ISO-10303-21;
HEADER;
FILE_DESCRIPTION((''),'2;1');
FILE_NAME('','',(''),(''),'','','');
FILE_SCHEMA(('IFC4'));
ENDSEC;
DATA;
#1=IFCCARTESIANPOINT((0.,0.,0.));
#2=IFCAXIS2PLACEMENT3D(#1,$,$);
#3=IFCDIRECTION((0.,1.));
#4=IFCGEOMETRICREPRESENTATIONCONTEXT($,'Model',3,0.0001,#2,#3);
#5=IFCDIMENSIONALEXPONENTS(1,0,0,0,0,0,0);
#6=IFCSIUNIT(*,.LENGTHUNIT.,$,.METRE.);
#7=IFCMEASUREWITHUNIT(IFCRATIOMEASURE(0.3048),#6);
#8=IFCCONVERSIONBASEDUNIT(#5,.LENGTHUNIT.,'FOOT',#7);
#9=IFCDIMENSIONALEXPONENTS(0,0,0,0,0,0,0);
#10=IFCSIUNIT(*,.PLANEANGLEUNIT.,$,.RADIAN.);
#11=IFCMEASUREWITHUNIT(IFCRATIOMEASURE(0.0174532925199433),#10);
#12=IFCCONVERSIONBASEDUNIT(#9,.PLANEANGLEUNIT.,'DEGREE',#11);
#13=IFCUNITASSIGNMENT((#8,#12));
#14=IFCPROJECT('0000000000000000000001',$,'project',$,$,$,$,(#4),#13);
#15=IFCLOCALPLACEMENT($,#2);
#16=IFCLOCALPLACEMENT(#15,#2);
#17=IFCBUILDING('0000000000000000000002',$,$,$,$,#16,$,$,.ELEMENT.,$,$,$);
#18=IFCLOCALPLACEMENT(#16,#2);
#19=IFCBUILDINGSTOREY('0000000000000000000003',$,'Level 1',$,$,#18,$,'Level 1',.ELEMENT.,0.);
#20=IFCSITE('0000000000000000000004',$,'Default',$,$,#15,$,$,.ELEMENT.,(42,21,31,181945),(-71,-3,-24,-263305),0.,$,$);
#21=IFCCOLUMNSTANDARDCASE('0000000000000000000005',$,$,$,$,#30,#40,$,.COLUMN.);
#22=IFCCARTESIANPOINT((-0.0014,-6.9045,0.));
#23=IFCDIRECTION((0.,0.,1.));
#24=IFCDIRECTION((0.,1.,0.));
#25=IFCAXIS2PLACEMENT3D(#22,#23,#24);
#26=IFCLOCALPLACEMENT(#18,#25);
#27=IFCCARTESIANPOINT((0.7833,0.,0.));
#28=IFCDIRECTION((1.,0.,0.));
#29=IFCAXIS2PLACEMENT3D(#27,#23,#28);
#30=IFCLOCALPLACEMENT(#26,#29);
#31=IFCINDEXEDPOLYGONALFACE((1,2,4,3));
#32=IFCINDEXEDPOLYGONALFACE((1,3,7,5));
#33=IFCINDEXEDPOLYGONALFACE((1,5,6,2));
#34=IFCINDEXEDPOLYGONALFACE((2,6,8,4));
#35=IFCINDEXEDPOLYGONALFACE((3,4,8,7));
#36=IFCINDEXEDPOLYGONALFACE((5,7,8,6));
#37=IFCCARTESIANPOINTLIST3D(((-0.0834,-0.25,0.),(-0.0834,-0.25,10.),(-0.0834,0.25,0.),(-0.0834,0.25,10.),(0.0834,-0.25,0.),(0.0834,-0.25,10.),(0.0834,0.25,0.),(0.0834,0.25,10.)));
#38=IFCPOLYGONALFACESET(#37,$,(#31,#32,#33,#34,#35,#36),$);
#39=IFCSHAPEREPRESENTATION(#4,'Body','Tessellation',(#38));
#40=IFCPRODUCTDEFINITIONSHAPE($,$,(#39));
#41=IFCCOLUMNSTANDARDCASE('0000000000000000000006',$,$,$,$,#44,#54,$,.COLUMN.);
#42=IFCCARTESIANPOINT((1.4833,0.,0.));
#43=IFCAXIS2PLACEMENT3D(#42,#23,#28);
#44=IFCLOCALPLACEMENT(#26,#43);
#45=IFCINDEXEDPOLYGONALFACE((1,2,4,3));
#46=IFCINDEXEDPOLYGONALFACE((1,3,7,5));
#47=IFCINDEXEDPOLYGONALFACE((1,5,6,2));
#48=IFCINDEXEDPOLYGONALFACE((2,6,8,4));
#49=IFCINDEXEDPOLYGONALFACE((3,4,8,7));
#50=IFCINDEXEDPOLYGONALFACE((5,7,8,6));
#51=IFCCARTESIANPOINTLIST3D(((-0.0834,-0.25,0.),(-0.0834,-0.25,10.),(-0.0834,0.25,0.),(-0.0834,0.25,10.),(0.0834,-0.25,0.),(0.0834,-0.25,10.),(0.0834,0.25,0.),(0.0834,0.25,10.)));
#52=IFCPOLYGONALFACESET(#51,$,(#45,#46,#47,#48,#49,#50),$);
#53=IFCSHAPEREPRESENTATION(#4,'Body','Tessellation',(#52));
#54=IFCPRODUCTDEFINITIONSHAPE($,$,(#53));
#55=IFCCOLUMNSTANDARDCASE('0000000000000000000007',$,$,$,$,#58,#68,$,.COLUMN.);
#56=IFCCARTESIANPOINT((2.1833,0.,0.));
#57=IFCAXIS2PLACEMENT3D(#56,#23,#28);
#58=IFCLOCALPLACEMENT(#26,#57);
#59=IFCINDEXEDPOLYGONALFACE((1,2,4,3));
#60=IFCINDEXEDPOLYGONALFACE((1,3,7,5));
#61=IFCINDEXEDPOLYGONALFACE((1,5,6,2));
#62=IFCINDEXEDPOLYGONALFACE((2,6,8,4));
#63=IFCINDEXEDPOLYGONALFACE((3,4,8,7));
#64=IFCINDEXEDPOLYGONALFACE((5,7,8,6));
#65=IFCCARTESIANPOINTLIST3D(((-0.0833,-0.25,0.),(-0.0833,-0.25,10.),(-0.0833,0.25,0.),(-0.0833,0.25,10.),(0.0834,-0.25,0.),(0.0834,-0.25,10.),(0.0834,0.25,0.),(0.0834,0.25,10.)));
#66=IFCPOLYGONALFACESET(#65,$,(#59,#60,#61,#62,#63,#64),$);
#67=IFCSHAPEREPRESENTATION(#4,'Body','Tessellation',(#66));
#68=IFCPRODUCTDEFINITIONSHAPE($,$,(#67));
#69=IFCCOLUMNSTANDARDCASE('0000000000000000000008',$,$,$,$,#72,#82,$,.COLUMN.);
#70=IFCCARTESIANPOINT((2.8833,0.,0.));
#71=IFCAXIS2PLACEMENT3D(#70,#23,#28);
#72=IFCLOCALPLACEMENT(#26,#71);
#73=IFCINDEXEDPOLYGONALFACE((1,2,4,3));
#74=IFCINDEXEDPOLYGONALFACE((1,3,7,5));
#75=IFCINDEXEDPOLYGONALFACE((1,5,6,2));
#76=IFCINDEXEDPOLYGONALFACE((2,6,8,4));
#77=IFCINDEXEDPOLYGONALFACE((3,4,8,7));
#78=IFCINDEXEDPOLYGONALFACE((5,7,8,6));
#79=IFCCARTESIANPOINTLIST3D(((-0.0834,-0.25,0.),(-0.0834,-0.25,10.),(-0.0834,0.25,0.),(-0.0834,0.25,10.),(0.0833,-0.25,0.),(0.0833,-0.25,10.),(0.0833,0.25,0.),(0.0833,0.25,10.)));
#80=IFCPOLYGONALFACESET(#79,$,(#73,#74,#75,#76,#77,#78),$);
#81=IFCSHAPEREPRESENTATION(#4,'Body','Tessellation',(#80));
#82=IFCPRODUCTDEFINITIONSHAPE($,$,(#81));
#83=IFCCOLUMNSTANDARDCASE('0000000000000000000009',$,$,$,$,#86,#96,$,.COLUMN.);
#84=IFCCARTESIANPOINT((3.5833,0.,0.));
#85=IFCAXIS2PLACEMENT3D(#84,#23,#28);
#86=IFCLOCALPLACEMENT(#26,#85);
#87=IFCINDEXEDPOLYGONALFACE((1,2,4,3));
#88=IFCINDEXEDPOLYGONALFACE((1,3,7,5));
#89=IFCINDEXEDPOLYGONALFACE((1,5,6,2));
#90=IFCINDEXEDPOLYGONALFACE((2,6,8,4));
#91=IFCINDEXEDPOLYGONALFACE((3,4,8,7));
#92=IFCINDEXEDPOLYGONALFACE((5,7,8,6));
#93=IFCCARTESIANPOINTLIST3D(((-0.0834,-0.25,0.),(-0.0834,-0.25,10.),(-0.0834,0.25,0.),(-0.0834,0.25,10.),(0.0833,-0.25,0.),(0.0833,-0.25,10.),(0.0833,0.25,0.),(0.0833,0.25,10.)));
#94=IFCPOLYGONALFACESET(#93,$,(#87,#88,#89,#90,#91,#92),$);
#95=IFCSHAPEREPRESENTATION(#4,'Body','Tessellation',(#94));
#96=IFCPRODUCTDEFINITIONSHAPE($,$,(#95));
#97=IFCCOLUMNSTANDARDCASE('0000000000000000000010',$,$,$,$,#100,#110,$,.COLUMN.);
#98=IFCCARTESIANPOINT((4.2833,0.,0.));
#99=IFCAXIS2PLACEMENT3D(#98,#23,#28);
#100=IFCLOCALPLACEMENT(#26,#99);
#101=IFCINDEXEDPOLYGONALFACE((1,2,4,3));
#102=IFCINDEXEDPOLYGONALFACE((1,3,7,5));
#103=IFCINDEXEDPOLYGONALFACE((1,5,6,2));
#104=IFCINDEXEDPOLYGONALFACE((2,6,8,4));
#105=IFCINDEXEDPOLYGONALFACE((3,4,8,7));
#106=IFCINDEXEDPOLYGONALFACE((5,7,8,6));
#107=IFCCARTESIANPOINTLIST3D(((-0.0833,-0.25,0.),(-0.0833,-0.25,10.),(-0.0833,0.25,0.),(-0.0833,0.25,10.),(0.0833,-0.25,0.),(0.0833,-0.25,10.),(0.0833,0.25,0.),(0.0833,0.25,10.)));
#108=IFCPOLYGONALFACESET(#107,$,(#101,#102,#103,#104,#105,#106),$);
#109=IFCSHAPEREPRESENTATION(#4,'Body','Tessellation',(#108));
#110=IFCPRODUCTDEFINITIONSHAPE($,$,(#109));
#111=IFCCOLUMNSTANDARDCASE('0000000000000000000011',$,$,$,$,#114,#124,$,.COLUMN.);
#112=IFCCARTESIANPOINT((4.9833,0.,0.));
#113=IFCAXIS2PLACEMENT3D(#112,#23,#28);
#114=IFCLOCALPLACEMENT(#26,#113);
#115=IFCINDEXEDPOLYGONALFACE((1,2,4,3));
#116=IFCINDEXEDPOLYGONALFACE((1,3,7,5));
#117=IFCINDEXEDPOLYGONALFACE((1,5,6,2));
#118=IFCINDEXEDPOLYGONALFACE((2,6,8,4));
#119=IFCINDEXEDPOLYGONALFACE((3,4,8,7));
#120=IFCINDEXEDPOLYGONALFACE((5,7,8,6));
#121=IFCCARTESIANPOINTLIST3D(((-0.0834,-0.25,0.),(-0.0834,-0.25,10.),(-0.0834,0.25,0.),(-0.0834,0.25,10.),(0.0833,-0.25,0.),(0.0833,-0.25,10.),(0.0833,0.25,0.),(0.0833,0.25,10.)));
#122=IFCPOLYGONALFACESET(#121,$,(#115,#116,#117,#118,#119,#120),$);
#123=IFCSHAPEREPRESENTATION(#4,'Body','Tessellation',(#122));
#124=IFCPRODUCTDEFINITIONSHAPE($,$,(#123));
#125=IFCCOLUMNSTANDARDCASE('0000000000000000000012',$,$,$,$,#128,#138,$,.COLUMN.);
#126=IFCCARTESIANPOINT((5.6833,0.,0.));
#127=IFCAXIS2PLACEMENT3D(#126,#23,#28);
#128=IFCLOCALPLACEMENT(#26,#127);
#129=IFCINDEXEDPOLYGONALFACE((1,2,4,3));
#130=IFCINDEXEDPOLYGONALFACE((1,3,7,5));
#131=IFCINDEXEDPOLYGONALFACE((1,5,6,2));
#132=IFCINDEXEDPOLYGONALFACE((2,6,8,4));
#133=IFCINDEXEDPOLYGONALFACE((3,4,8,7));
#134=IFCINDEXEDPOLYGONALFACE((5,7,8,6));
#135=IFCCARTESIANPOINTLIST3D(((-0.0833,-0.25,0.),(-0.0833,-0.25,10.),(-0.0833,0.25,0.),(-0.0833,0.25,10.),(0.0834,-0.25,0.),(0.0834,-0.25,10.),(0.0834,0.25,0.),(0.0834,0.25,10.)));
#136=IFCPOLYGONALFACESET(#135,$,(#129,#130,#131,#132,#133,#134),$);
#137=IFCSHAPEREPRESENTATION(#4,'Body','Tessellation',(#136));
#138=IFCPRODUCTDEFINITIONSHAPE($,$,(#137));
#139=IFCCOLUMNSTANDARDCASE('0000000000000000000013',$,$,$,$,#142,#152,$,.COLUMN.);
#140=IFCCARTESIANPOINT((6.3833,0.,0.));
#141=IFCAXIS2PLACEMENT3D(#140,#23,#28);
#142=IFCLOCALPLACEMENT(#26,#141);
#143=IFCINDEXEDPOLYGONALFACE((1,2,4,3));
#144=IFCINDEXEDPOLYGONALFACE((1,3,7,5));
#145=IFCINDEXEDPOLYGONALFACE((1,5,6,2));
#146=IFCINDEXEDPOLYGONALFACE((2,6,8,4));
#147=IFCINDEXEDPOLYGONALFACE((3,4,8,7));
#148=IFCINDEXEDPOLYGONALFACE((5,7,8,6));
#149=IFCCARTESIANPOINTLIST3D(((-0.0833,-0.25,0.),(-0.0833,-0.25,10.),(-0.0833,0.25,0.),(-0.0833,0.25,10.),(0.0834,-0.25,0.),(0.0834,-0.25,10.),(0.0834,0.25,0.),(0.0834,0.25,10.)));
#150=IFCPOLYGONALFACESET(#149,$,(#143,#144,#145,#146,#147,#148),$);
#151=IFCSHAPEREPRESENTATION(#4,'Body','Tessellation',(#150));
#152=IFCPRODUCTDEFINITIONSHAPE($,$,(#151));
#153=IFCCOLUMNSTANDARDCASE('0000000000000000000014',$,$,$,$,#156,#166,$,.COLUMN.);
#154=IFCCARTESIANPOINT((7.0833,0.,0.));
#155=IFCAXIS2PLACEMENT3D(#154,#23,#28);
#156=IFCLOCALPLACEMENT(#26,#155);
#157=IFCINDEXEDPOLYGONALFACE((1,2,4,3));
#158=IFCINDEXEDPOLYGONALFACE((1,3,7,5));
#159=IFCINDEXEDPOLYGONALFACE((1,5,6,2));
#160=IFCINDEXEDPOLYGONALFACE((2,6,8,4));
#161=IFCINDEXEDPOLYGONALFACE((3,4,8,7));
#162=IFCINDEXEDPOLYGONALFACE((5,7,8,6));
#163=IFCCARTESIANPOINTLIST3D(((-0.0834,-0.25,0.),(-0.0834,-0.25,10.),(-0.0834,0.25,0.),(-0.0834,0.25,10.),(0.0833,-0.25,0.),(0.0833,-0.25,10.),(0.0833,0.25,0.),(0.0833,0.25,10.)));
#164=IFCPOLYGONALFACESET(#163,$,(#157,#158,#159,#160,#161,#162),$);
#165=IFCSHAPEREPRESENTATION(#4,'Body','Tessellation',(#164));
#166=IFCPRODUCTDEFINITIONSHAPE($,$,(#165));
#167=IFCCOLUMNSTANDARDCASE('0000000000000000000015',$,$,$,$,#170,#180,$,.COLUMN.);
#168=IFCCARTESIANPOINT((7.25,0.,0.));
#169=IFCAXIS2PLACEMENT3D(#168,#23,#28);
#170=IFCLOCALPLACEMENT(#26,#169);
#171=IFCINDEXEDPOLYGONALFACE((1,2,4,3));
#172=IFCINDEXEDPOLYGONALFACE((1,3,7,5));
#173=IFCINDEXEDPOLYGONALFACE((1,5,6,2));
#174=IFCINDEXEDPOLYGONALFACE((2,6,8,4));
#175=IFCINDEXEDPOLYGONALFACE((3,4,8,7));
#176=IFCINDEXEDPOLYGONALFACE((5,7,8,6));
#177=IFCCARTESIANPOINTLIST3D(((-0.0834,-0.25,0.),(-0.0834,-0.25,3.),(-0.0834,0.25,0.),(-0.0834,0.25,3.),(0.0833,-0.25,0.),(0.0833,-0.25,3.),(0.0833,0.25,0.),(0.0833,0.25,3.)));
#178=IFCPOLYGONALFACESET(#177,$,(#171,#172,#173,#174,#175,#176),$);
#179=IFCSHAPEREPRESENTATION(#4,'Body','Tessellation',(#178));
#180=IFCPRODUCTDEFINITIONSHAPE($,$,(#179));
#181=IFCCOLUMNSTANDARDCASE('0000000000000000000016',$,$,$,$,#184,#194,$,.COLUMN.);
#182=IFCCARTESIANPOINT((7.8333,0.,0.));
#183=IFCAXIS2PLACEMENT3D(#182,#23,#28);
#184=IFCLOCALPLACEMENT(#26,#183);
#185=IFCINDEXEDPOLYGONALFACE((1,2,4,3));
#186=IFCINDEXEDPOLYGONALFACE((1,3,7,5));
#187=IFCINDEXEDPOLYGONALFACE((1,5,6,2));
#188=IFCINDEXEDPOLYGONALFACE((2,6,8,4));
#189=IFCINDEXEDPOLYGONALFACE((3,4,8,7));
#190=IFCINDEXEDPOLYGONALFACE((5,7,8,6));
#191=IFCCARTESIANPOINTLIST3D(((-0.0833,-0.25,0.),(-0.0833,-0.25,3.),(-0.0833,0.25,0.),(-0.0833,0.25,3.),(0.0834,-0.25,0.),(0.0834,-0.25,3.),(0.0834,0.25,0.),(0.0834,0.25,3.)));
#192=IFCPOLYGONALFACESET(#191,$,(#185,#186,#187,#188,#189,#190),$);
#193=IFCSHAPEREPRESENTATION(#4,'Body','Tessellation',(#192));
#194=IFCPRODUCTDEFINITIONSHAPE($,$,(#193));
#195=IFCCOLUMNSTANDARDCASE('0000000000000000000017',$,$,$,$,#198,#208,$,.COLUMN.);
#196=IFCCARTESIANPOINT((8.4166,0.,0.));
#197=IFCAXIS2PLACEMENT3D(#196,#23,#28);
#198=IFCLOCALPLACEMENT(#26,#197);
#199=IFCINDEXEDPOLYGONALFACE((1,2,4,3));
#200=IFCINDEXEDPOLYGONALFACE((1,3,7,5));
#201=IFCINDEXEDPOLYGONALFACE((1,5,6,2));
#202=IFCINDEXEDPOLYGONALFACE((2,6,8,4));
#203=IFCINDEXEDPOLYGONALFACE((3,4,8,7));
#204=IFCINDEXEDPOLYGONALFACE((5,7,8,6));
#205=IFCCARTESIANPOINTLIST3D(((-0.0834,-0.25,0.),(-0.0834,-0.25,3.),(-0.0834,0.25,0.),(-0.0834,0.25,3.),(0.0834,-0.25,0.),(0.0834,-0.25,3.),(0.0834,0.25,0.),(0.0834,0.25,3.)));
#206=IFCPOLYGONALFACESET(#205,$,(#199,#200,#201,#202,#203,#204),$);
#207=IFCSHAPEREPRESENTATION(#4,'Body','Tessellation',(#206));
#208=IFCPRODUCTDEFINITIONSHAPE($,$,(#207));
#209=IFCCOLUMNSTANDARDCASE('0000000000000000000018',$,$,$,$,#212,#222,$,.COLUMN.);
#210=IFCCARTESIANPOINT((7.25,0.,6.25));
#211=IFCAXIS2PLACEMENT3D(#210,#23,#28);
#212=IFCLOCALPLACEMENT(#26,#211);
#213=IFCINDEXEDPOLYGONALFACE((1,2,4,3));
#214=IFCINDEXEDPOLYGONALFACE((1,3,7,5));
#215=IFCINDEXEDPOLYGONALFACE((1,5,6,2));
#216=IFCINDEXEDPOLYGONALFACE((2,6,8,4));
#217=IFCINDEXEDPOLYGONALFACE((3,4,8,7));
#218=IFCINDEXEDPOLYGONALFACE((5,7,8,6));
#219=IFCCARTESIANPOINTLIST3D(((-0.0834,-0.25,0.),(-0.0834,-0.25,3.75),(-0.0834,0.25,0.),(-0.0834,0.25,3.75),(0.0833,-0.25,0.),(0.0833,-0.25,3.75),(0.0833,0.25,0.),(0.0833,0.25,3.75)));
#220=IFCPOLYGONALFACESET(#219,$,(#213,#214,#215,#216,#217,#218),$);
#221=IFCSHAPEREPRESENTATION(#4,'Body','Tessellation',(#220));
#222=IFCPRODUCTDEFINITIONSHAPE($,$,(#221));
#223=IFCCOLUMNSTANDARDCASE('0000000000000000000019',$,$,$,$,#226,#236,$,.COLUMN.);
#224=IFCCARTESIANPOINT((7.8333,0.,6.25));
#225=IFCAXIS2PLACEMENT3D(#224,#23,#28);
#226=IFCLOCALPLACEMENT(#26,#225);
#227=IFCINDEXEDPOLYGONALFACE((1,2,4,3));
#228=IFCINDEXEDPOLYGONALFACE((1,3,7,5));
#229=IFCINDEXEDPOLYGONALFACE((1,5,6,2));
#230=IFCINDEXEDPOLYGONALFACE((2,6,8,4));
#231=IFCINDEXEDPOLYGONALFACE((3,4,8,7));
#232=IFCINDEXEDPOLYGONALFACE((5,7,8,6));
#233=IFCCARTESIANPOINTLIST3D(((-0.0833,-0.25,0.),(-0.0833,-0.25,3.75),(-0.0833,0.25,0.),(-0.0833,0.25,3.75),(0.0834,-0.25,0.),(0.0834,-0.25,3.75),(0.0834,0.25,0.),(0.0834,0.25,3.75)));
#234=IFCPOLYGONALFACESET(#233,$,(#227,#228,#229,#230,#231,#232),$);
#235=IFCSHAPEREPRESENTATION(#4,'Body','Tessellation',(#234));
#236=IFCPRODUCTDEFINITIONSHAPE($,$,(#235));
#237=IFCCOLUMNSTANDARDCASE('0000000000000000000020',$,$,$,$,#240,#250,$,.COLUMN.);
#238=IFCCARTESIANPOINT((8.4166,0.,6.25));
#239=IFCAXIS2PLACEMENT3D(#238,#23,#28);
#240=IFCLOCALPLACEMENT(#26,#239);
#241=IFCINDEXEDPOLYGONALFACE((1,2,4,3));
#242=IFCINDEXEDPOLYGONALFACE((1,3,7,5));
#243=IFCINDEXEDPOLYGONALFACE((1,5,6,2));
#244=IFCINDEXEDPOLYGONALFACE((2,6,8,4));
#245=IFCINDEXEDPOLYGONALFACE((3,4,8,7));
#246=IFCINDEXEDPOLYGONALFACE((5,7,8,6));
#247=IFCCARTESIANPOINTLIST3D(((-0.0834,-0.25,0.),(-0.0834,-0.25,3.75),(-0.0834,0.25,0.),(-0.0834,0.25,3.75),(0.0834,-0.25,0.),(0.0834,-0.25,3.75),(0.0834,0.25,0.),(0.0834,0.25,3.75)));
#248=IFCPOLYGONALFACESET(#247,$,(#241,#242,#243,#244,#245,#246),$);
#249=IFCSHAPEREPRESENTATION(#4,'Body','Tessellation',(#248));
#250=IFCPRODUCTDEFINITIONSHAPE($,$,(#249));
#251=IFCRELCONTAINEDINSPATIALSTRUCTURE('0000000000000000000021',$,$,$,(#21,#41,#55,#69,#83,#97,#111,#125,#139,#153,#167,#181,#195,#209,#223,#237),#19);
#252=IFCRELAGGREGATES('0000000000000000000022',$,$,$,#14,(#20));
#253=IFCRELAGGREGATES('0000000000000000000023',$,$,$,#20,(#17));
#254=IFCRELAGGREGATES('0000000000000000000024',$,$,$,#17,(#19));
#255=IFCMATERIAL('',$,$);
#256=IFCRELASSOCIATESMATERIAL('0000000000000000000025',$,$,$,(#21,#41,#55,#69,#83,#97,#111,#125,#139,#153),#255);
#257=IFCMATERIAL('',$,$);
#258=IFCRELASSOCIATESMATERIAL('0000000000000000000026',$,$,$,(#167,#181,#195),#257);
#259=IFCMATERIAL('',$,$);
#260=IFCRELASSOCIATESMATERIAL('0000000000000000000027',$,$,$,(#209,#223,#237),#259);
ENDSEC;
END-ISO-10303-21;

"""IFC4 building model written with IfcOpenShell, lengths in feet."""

from ifc_helpers import new_model, entity, si_unit, converted_unit, direction, frame, origin, place, context, project, spatial, rectangle, extrude, material, element, save


model = new_model("IFC4")

# Units and contexts
model_context = context("Model", 3, precision=0.0001, world=origin(), true_north=direction((0.0, 1.0)))
ifc_project = project(units=[converted_unit("LENGTHUNIT", "FOOT", entity("IfcRatioMeasure", 0.3048), si_unit("LENGTHUNIT", "METRE"), dimensions=[1, 0, 0, 0, 0, 0, 0]), converted_unit("PLANEANGLEUNIT", "DEGREE", entity("IfcRatioMeasure", 0.0174532925199433), si_unit("PLANEANGLEUNIT", "RADIAN"), dimensions=[0, 0, 0, 0, 0, 0, 0])], contexts=[model_context])

# Site, building, storey
site_placement = place(None, origin())
site = spatial("IfcSite", under=ifc_project, at=site_placement, Name="Default", CompositionType="ELEMENT", RefLatitude=(42, 21, 31, 181945), RefLongitude=(-71, -3, -24, -263305), RefElevation=0.0)
building_placement = place(site_placement, origin())
building = spatial("IfcBuilding", under=site, at=building_placement, CompositionType="ELEMENT")
storey_placement = place(building_placement, origin())
storey = spatial("IfcBuildingStorey", under=building, at=storey_placement, Name="Level 1", LongName="Level 1", CompositionType="ELEMENT", Elevation=0.0)

# Columns
ifc_material_1 = material(Name="")
wall_placement = place(storey_placement, frame((-0.0014, -6.9045, 0.0), z_axis=(0.0, 0.0, 1.0), x_axis=(0.0, 1.0, 0.0)))
for number, where, z_axis, x_axis in (
    (1, (0.7833, 0.0, 0.0), (0.0, 0.0, 1.0), (1.0, 0.0, 0.0)),
    (2, (1.4833, 0.0, 0.0), (0.0, 0.0, 1.0), (1.0, 0.0, 0.0)),
    (3, (2.1833, 0.0, 0.0), (0.0, 0.0, 1.0), (1.0, 0.0, 0.0)),
    (4, (2.8833, 0.0, 0.0), (0.0, 0.0, 1.0), (1.0, 0.0, 0.0)),
    (5, (3.5833, 0.0, 0.0), (0.0, 0.0, 1.0), (1.0, 0.0, 0.0)),
    (6, (4.2833, 0.0, 0.0), (0.0, 0.0, 1.0), (1.0, 0.0, 0.0)),
    (7, (4.9833, 0.0, 0.0), (0.0, 0.0, 1.0), (1.0, 0.0, 0.0)),
    (8, (5.6833, 0.0, 0.0), (0.0, 0.0, 1.0), (1.0, 0.0, 0.0)),
    (9, (6.3833, 0.0, 0.0), (0.0, 0.0, 1.0), (1.0, 0.0, 0.0)),
    (10, (7.0833, 0.0, 0.0), (0.0, 0.0, 1.0), (1.0, 0.0, 0.0)),
):
    element("IfcColumnStandardCase", number, at=place(wall_placement, frame(where, z_axis=z_axis, x_axis=x_axis)), inside=storey, material=ifc_material_1, PredefinedType="COLUMN", context=model_context, shape_type="SweptSolid", body=[
        extrude(rectangle(XDim=0.1667, YDim=0.5), origin(), (0.0, 0.0, 1.0), 10.0),
    ])
ifc_material_2 = material(Name="")
for number, where, z_axis, x_axis in (
    (11, (7.25, 0.0, 0.0), (0.0, 0.0, 1.0), (1.0, 0.0, 0.0)),
    (12, (7.8333, 0.0, 0.0), (0.0, 0.0, 1.0), (1.0, 0.0, 0.0)),
    (13, (8.4166, 0.0, 0.0), (0.0, 0.0, 1.0), (1.0, 0.0, 0.0)),
):
    element("IfcColumnStandardCase", number, at=place(wall_placement, frame(where, z_axis=z_axis, x_axis=x_axis)), inside=storey, material=ifc_material_2, PredefinedType="COLUMN", context=model_context, shape_type="SweptSolid", body=[
        extrude(rectangle(XDim=0.1667, YDim=0.5), origin(), (0.0, 0.0, 1.0), 3.0),
    ])
ifc_material_3 = material(Name="")
for number, where, z_axis, x_axis in (
    (14, (7.25, 0.0, 6.25), (0.0, 0.0, 1.0), (1.0, 0.0, 0.0)),
    (15, (7.8333, 0.0, 6.25), (0.0, 0.0, 1.0), (1.0, 0.0, 0.0)),
    (16, (8.4166, 0.0, 6.25), (0.0, 0.0, 1.0), (1.0, 0.0, 0.0)),
):
    element("IfcColumnStandardCase", number, at=place(wall_placement, frame(where, z_axis=z_axis, x_axis=x_axis)), inside=storey, material=ifc_material_3, PredefinedType="COLUMN", context=model_context, shape_type="SweptSolid", body=[
        extrude(rectangle(XDim=0.1667, YDim=0.5), origin(), (0.0, 0.0, 1.0), 3.75),
    ])

save(model, "model.ifc")
